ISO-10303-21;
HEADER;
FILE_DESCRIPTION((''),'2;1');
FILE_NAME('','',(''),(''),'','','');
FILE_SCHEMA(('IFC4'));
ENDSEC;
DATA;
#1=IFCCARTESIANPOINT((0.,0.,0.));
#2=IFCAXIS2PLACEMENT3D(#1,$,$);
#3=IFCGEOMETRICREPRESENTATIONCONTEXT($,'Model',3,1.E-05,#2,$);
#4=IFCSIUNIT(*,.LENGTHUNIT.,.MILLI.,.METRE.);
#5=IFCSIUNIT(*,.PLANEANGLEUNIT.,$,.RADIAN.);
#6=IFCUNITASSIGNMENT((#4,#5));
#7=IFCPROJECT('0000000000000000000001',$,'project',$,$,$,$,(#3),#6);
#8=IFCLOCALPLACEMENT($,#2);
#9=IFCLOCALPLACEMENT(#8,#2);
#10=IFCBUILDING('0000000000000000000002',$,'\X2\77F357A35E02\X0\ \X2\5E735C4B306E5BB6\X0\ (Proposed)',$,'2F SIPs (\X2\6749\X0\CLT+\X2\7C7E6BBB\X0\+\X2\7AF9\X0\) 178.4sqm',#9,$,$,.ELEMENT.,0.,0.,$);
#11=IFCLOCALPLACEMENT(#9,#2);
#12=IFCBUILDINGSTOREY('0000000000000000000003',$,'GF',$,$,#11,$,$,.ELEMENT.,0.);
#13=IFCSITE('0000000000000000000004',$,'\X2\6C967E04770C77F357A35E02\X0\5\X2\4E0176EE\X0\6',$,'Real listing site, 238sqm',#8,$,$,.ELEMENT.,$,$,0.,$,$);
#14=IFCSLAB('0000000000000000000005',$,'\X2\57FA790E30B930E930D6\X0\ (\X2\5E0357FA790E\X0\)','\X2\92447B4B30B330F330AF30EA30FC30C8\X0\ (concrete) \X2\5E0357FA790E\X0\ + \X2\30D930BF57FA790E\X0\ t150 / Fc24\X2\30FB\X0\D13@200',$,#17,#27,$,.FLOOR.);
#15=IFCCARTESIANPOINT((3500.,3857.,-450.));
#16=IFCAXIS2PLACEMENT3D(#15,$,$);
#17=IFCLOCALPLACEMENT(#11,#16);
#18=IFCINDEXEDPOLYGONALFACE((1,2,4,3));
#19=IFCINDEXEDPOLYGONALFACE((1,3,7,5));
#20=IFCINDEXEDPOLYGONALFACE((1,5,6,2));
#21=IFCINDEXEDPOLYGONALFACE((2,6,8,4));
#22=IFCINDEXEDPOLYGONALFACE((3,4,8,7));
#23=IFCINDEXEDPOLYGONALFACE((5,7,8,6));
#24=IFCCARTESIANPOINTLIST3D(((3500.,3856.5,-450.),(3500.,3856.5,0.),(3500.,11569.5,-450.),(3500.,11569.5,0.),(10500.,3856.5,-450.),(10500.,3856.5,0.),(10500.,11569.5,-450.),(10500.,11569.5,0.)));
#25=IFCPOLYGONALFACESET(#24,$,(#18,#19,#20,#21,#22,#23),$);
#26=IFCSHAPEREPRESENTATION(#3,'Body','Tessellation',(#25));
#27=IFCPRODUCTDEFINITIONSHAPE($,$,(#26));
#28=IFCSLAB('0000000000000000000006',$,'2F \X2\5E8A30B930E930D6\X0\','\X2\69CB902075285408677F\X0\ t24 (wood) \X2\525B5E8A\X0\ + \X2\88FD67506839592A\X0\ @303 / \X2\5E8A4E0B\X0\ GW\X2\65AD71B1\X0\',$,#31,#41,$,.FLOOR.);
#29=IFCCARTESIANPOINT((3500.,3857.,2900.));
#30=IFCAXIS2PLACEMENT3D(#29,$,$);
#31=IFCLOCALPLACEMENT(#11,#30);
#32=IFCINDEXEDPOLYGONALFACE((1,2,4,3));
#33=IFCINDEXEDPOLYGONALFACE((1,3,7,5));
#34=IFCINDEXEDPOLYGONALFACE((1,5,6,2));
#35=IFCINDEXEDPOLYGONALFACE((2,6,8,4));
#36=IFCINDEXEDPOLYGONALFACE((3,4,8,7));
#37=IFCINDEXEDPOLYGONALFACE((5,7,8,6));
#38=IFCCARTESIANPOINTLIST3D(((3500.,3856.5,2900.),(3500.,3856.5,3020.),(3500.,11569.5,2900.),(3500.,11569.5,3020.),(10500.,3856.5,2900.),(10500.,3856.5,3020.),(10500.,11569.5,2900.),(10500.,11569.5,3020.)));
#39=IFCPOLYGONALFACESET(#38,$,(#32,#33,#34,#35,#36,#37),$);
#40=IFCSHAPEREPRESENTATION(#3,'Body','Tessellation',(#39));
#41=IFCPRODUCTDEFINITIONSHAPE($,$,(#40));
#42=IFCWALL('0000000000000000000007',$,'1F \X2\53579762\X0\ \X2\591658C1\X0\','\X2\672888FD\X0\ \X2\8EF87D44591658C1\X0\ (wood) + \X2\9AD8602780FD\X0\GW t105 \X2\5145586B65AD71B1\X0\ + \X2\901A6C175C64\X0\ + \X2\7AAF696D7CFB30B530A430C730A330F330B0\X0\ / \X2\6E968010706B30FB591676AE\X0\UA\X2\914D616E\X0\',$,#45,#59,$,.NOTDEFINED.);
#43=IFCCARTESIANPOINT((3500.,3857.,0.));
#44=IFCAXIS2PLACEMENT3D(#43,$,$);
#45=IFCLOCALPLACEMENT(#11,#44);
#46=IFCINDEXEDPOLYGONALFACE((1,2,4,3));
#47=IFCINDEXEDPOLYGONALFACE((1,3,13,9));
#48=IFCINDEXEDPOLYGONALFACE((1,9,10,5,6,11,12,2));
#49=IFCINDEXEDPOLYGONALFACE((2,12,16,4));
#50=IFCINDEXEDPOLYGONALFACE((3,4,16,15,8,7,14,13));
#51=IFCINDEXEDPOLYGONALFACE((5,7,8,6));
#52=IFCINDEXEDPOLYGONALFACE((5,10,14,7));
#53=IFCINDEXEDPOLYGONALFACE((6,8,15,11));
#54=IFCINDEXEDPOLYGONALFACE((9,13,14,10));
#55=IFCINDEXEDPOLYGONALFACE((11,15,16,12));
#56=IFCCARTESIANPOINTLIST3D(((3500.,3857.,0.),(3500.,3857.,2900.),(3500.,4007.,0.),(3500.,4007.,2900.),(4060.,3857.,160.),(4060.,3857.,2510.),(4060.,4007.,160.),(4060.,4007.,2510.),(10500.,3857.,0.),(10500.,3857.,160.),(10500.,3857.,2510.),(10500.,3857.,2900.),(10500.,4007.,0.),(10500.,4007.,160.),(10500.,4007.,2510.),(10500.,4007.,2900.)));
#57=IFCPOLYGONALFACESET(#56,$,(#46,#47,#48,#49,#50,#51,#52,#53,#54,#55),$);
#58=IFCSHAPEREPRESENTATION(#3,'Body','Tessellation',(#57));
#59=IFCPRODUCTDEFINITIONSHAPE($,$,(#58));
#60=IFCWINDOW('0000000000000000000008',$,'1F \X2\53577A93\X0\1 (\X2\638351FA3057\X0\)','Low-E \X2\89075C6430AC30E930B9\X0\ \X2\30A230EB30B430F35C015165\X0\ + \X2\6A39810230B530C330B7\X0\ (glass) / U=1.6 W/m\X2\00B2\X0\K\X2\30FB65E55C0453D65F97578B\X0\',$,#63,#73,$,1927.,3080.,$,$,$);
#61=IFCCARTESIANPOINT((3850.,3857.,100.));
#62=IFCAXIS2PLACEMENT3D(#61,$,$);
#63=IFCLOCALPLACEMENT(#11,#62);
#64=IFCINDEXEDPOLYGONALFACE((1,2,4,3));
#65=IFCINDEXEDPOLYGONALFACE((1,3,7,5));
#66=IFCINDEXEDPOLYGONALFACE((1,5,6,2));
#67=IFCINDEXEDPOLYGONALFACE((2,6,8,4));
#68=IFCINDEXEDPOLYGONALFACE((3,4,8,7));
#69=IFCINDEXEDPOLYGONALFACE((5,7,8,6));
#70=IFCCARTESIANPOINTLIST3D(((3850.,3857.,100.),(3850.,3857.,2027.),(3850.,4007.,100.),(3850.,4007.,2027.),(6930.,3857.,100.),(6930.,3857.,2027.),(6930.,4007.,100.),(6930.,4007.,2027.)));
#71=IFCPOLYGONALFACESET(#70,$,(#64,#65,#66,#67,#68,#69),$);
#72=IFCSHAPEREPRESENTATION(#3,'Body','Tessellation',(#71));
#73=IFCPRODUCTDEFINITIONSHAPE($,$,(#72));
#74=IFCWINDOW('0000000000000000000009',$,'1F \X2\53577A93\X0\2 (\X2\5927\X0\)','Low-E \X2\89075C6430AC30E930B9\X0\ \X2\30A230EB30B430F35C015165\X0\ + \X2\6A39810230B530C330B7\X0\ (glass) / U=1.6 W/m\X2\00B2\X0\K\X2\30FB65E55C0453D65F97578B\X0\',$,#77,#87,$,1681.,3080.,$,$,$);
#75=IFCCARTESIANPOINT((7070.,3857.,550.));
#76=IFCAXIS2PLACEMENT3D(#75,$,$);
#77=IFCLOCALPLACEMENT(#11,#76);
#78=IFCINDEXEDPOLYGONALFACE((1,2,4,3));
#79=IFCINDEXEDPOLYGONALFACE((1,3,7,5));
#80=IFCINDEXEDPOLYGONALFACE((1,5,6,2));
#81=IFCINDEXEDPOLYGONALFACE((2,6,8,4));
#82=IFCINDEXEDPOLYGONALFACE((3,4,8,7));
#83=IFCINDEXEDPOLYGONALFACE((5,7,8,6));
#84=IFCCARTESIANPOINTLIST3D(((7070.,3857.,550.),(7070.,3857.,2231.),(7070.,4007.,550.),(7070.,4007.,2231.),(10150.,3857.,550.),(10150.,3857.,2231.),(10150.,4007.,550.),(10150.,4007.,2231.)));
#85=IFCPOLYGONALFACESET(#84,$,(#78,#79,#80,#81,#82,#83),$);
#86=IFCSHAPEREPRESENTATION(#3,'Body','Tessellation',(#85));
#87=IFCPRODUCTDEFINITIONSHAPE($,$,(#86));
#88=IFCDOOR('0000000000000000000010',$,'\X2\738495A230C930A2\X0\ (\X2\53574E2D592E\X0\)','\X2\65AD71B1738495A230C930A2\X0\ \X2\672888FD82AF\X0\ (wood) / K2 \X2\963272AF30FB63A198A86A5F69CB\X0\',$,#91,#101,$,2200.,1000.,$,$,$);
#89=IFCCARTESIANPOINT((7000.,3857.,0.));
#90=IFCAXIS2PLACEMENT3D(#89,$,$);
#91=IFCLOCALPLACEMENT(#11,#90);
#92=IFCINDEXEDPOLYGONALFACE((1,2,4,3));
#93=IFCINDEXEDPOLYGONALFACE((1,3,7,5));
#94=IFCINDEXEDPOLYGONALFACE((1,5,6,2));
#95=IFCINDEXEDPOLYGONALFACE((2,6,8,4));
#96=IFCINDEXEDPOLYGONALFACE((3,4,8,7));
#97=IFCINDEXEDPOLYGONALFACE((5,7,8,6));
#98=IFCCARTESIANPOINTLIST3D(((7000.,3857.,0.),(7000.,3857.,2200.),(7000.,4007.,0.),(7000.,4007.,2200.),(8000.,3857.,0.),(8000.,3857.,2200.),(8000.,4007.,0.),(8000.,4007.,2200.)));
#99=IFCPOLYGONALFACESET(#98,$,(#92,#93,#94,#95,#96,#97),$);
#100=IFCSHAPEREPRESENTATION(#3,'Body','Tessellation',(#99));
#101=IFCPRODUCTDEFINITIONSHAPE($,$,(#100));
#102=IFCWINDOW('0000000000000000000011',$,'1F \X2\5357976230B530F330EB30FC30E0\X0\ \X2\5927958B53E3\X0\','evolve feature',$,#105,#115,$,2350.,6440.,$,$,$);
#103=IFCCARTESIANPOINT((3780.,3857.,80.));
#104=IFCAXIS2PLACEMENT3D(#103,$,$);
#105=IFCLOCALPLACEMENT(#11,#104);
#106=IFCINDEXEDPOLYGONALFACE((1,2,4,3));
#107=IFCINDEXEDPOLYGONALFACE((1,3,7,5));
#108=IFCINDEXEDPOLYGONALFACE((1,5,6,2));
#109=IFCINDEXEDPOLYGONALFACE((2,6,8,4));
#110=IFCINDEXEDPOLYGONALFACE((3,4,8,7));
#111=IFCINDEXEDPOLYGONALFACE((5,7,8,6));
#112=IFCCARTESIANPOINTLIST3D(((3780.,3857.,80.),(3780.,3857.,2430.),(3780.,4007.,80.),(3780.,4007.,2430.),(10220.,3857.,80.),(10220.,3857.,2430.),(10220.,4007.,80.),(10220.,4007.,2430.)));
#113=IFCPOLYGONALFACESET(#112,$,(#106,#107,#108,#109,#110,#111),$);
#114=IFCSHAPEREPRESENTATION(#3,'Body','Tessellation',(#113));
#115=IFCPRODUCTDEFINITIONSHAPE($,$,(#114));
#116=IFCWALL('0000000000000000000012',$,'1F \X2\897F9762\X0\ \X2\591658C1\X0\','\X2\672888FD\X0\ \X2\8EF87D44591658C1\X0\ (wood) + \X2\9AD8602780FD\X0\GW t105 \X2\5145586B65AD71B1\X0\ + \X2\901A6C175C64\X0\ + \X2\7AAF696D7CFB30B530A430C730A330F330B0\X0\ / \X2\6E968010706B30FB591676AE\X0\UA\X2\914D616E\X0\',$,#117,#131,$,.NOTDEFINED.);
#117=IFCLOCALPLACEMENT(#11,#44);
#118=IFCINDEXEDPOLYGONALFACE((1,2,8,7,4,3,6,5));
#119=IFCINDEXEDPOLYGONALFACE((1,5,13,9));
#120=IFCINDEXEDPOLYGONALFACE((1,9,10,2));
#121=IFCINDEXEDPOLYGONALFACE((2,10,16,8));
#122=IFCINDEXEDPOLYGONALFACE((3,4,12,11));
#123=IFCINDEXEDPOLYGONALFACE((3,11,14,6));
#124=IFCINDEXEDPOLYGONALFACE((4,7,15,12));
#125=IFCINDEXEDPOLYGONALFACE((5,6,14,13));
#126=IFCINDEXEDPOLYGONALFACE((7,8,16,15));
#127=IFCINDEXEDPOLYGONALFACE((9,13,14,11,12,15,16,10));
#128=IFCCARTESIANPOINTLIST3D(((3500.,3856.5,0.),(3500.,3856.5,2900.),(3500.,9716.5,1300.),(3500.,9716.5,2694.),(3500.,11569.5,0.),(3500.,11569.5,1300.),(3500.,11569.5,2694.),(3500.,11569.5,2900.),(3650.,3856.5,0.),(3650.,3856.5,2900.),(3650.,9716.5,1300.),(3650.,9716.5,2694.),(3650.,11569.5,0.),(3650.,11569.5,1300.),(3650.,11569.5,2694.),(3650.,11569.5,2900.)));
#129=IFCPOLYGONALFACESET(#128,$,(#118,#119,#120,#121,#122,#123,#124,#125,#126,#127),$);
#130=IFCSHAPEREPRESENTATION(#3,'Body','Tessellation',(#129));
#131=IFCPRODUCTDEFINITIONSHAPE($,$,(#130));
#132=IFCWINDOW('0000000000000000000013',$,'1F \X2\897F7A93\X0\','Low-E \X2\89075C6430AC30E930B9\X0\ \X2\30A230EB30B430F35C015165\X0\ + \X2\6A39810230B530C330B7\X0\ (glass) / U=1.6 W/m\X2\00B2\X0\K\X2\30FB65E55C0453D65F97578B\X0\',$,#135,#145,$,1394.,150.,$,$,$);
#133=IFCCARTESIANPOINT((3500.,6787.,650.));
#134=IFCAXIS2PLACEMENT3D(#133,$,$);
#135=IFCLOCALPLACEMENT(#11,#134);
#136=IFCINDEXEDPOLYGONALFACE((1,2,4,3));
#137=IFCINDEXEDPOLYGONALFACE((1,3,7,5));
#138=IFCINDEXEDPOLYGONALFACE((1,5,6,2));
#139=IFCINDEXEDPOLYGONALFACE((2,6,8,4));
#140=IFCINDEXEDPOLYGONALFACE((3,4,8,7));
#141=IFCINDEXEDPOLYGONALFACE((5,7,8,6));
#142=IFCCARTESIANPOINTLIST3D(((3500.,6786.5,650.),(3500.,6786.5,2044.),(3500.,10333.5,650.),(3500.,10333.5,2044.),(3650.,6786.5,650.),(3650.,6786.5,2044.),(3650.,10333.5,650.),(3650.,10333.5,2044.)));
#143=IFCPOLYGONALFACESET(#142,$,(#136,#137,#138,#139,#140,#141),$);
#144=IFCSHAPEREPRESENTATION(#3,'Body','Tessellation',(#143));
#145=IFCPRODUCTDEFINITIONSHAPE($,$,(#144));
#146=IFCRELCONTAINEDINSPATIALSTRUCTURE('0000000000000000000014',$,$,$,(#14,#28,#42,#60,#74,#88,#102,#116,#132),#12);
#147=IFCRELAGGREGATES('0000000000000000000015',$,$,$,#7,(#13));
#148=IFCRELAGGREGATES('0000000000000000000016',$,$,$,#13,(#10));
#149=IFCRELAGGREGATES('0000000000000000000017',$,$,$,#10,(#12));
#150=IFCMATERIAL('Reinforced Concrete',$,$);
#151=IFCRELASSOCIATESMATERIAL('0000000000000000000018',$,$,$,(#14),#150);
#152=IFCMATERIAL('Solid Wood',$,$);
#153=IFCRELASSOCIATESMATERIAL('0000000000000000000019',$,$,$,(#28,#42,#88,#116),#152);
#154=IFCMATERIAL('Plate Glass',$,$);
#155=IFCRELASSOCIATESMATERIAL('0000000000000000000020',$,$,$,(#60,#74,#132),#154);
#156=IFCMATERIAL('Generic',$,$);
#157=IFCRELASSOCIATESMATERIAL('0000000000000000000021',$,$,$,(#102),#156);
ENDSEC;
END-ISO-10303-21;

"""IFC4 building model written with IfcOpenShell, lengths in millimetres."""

from ifc_helpers import new_model, si_unit, frame, frame_2d, origin, place, context, project, spatial, rectangle, extrude, material, element, fill, save


model = new_model("IFC4")

# Units and contexts
model_context = context("Model", 3, precision=1e-05, world=origin())
ifc_project = project(units=[si_unit("LENGTHUNIT", "METRE", prefix="MILLI"), si_unit("PLANEANGLEUNIT", "RADIAN")], contexts=[model_context])

# Site, building, storey
site_placement = place(None, origin())
site = spatial("IfcSite", under=ifc_project, at=site_placement, Name="沖縄県石垣市5丁目6", ObjectType="Real listing site, 238sqm", CompositionType="ELEMENT", RefElevation=0.0)
building_placement = place(site_placement, origin())
building = spatial("IfcBuilding", under=site, at=building_placement, Name="石垣市 平屋の家 (Proposed)", ObjectType="2F SIPs (杉CLT+籾殻+竹) 178.4sqm", CompositionType="ELEMENT", ElevationOfRefHeight=0.0, ElevationOfTerrain=0.0)
storey_placement = place(building_placement, origin())
storey = spatial("IfcBuildingStorey", under=building, at=storey_placement, Name="GF", CompositionType="ELEMENT", Elevation=0.0)

# Slabs
ifc_material_1 = material(Name="Reinforced Concrete")
slab_1_placement = place(storey_placement, frame((3500.0, 3857.0, -450.0)))
element("IfcSlab", 1, at=slab_1_placement, inside=storey, material=ifc_material_1, Name="基礎スラブ (布基礎)", Description="鉄筋コンクリート (concrete) 布基礎 + ベタ基礎 t150 / Fc24・D13@200", PredefinedType="FLOOR", context=model_context, shape_type="SweptSolid", body=[
    extrude(rectangle(XDim=7000.0, YDim=7713.0, at=frame_2d((3500.0, 3856.0))), frame((3500.0, 3857.0, -450.0)), (0.0, 0.0, 1.0), 450.0),
])
ifc_material_2 = material(Name="Solid Wood")
slab_2_placement = place(storey_placement, frame((3500.0, 3857.0, 2900.0)))
element("IfcSlab", 2, at=slab_2_placement, inside=storey, material=ifc_material_2, Name="2F 床スラブ", Description="構造用合板 t24 (wood) 剛床 + 製材根太 @303 / 床下 GW断熱", PredefinedType="FLOOR", context=model_context, shape_type="SweptSolid", body=[
    extrude(rectangle(XDim=7000.0, YDim=7713.0, at=frame_2d((3500.0, 3856.0))), frame((3500.0, 3857.0, 2900.0)), (0.0, 0.0, 1.0), 120.0),
])
ifc_material_3 = material(Name="Generic")

# Wall, openings, windows, door
wall_1_placement = place(storey_placement, frame((3500.0, 3857.0, 0.0)))
wall_1 = element("IfcWall", 3, at=wall_1_placement, inside=storey, material=ifc_material_2, Name="1F 南面 外壁", Description="木製 軸組外壁 (wood) + 高性能GW t105 充填断熱 + 通気層 + 窯業系サイディング / 準耐火・外皮UA配慮", PredefinedType="NOTDEFINED", context=model_context, shape_type="SweptSolid", body=[
    extrude(rectangle(XDim=7000.0, YDim=150.0, at=frame_2d((3500.0, 75.0))), frame((3500.0, 3857.0, 0.0)), (0.0, 0.0, 1.0), 2900.0),
])
opening_1_placement = place(storey_placement, frame((3850.0, 3857.0, 100.0)))
opening_1 = element("IfcOpeningElement", 4, at=opening_1_placement, cuts=wall_1, PredefinedType="NOTDEFINED", context=model_context, shape_type="SweptSolid", body=[
    extrude(rectangle(XDim=3080.0, YDim=150.0, at=frame_2d((1540.0, 75.0))), frame((3850.0, 3857.0, 100.0)), (0.0, 0.0, 1.0), 1927.0),
])
opening_2_placement = place(storey_placement, frame((7070.0, 3857.0, 550.0)))
opening_2 = element("IfcOpeningElement", 5, at=opening_2_placement, cuts=wall_1, PredefinedType="NOTDEFINED", context=model_context, shape_type="SweptSolid", body=[
    extrude(rectangle(XDim=3080.0, YDim=150.0, at=frame_2d((1540.0, 75.0))), frame((7070.0, 3857.0, 550.0)), (0.0, 0.0, 1.0), 1681.0),
])
opening_3_placement = place(storey_placement, frame((7000.0, 3857.0, 0.0)))
opening_3 = element("IfcOpeningElement", 6, at=opening_3_placement, cuts=wall_1, PredefinedType="NOTDEFINED", context=model_context, shape_type="SweptSolid", body=[
    extrude(rectangle(XDim=1000.0, YDim=150.0, at=frame_2d((500.0, 75.0))), frame((7000.0, 3857.0, 0.0)), (0.0, 0.0, 1.0), 2200.0),
])
opening_4_placement = place(storey_placement, frame((3780.0, 3857.0, 80.0)))
opening_4 = element("IfcOpeningElement", 7, at=opening_4_placement, cuts=wall_1, PredefinedType="NOTDEFINED", context=model_context, shape_type="SweptSolid", body=[
    extrude(rectangle(XDim=6440.0, YDim=150.0, at=frame_2d((3220.0, 75.0))), frame((3780.0, 3857.0, 80.0)), (0.0, 0.0, 1.0), 2350.0),
])
ifc_material_4 = material(Name="Plate Glass")
window_1_placement = place(storey_placement, frame((3850.0, 3857.0, 100.0)))
window_1 = element("IfcWindow", 8, at=window_1_placement, inside=storey, material=ifc_material_4, Name="1F 南窓1 (掃出し)", Description="Low-E 複層ガラス アルゴン封入 + 樹脂サッシ (glass) / U=1.6 W/m²K・日射取得型", OverallHeight=1927.0, OverallWidth=3080.0, context=model_context, shape_type="SweptSolid", body=[
    extrude(rectangle(XDim=3080.0, YDim=150.0, at=frame_2d((1540.0, 75.0))), frame((3850.0, 3857.0, 100.0)), (0.0, 0.0, 1.0), 1927.0),
])
fill(opening_1, window_1)
window_2_placement = place(storey_placement, frame((7070.0, 3857.0, 550.0)))
window_2 = element("IfcWindow", 9, at=window_2_placement, inside=storey, material=ifc_material_4, Name="1F 南窓2 (大)", Description="Low-E 複層ガラス アルゴン封入 + 樹脂サッシ (glass) / U=1.6 W/m²K・日射取得型", OverallHeight=1681.0, OverallWidth=3080.0, context=model_context, shape_type="SweptSolid", body=[
    extrude(rectangle(XDim=3080.0, YDim=150.0, at=frame_2d((1540.0, 75.0))), frame((7070.0, 3857.0, 550.0)), (0.0, 0.0, 1.0), 1681.0),
])
fill(opening_2, window_2)
door_placement = place(storey_placement, frame((7000.0, 3857.0, 0.0)))
door = element("IfcDoor", 10, at=door_placement, inside=storey, material=ifc_material_2, Name="玄関ドア (南中央)", Description="断熱玄関ドア 木製芯 (wood) / K2 防犯・採風機構", OverallHeight=2200.0, OverallWidth=1000.0, context=model_context, shape_type="SweptSolid", body=[
    extrude(rectangle(XDim=1000.0, YDim=150.0, at=frame_2d((500.0, 75.0))), frame((7000.0, 3857.0, 0.0)), (0.0, 0.0, 1.0), 2200.0),
])
fill(opening_3, door)
window_3_placement = place(storey_placement, frame((3780.0, 3857.0, 80.0)))
window_3 = element("IfcWindow", 11, at=window_3_placement, inside=storey, material=ifc_material_3, Name="1F 南面サンルーム 大開口", Description="evolve feature", OverallHeight=2350.0, OverallWidth=6440.0, context=model_context, shape_type="SweptSolid", body=[
    extrude(rectangle(XDim=6440.0, YDim=150.0, at=frame_2d((3220.0, 75.0))), frame((3780.0, 3857.0, 80.0)), (0.0, 0.0, 1.0), 2350.0),
])
fill(opening_4, window_3)

# Wall, opening, window
wall_2_placement = place(storey_placement, frame((3500.0, 3857.0, 0.0)))
wall_2 = element("IfcWall", 12, at=wall_2_placement, inside=storey, material=ifc_material_2, Name="1F 西面 外壁", Description="木製 軸組外壁 (wood) + 高性能GW t105 充填断熱 + 通気層 + 窯業系サイディング / 準耐火・外皮UA配慮", PredefinedType="NOTDEFINED", context=model_context, shape_type="SweptSolid", body=[
    extrude(rectangle(XDim=150.0, YDim=7713.0, at=frame_2d((75.0, 3856.0))), frame((3500.0, 3857.0, 0.0)), (0.0, 0.0, 1.0), 2900.0),
])
opening_5_placement = place(storey_placement, frame((3500.0, 6787.0, 650.0)))
opening_5 = element("IfcOpeningElement", 13, at=opening_5_placement, cuts=wall_2, PredefinedType="NOTDEFINED", context=model_context, shape_type="SweptSolid", body=[
    extrude(rectangle(XDim=150.0, YDim=3547.0, at=frame_2d((75.0, 1773.0))), frame((3500.0, 6787.0, 650.0)), (0.0, 0.0, 1.0), 1394.0),
])
window_4_placement = place(storey_placement, frame((3500.0, 6787.0, 650.0)))
window_4 = element("IfcWindow", 14, at=window_4_placement, inside=storey, material=ifc_material_4, Name="1F 西窓", Description="Low-E 複層ガラス アルゴン封入 + 樹脂サッシ (glass) / U=1.6 W/m²K・日射取得型", OverallHeight=1394.0, OverallWidth=150.0, context=model_context, shape_type="SweptSolid", body=[
    extrude(rectangle(XDim=150.0, YDim=3547.0, at=frame_2d((75.0, 1773.0))), frame((3500.0, 6787.0, 650.0)), (0.0, 0.0, 1.0), 1394.0),
])
fill(opening_5, window_4)

save(model, "model.ifc")
